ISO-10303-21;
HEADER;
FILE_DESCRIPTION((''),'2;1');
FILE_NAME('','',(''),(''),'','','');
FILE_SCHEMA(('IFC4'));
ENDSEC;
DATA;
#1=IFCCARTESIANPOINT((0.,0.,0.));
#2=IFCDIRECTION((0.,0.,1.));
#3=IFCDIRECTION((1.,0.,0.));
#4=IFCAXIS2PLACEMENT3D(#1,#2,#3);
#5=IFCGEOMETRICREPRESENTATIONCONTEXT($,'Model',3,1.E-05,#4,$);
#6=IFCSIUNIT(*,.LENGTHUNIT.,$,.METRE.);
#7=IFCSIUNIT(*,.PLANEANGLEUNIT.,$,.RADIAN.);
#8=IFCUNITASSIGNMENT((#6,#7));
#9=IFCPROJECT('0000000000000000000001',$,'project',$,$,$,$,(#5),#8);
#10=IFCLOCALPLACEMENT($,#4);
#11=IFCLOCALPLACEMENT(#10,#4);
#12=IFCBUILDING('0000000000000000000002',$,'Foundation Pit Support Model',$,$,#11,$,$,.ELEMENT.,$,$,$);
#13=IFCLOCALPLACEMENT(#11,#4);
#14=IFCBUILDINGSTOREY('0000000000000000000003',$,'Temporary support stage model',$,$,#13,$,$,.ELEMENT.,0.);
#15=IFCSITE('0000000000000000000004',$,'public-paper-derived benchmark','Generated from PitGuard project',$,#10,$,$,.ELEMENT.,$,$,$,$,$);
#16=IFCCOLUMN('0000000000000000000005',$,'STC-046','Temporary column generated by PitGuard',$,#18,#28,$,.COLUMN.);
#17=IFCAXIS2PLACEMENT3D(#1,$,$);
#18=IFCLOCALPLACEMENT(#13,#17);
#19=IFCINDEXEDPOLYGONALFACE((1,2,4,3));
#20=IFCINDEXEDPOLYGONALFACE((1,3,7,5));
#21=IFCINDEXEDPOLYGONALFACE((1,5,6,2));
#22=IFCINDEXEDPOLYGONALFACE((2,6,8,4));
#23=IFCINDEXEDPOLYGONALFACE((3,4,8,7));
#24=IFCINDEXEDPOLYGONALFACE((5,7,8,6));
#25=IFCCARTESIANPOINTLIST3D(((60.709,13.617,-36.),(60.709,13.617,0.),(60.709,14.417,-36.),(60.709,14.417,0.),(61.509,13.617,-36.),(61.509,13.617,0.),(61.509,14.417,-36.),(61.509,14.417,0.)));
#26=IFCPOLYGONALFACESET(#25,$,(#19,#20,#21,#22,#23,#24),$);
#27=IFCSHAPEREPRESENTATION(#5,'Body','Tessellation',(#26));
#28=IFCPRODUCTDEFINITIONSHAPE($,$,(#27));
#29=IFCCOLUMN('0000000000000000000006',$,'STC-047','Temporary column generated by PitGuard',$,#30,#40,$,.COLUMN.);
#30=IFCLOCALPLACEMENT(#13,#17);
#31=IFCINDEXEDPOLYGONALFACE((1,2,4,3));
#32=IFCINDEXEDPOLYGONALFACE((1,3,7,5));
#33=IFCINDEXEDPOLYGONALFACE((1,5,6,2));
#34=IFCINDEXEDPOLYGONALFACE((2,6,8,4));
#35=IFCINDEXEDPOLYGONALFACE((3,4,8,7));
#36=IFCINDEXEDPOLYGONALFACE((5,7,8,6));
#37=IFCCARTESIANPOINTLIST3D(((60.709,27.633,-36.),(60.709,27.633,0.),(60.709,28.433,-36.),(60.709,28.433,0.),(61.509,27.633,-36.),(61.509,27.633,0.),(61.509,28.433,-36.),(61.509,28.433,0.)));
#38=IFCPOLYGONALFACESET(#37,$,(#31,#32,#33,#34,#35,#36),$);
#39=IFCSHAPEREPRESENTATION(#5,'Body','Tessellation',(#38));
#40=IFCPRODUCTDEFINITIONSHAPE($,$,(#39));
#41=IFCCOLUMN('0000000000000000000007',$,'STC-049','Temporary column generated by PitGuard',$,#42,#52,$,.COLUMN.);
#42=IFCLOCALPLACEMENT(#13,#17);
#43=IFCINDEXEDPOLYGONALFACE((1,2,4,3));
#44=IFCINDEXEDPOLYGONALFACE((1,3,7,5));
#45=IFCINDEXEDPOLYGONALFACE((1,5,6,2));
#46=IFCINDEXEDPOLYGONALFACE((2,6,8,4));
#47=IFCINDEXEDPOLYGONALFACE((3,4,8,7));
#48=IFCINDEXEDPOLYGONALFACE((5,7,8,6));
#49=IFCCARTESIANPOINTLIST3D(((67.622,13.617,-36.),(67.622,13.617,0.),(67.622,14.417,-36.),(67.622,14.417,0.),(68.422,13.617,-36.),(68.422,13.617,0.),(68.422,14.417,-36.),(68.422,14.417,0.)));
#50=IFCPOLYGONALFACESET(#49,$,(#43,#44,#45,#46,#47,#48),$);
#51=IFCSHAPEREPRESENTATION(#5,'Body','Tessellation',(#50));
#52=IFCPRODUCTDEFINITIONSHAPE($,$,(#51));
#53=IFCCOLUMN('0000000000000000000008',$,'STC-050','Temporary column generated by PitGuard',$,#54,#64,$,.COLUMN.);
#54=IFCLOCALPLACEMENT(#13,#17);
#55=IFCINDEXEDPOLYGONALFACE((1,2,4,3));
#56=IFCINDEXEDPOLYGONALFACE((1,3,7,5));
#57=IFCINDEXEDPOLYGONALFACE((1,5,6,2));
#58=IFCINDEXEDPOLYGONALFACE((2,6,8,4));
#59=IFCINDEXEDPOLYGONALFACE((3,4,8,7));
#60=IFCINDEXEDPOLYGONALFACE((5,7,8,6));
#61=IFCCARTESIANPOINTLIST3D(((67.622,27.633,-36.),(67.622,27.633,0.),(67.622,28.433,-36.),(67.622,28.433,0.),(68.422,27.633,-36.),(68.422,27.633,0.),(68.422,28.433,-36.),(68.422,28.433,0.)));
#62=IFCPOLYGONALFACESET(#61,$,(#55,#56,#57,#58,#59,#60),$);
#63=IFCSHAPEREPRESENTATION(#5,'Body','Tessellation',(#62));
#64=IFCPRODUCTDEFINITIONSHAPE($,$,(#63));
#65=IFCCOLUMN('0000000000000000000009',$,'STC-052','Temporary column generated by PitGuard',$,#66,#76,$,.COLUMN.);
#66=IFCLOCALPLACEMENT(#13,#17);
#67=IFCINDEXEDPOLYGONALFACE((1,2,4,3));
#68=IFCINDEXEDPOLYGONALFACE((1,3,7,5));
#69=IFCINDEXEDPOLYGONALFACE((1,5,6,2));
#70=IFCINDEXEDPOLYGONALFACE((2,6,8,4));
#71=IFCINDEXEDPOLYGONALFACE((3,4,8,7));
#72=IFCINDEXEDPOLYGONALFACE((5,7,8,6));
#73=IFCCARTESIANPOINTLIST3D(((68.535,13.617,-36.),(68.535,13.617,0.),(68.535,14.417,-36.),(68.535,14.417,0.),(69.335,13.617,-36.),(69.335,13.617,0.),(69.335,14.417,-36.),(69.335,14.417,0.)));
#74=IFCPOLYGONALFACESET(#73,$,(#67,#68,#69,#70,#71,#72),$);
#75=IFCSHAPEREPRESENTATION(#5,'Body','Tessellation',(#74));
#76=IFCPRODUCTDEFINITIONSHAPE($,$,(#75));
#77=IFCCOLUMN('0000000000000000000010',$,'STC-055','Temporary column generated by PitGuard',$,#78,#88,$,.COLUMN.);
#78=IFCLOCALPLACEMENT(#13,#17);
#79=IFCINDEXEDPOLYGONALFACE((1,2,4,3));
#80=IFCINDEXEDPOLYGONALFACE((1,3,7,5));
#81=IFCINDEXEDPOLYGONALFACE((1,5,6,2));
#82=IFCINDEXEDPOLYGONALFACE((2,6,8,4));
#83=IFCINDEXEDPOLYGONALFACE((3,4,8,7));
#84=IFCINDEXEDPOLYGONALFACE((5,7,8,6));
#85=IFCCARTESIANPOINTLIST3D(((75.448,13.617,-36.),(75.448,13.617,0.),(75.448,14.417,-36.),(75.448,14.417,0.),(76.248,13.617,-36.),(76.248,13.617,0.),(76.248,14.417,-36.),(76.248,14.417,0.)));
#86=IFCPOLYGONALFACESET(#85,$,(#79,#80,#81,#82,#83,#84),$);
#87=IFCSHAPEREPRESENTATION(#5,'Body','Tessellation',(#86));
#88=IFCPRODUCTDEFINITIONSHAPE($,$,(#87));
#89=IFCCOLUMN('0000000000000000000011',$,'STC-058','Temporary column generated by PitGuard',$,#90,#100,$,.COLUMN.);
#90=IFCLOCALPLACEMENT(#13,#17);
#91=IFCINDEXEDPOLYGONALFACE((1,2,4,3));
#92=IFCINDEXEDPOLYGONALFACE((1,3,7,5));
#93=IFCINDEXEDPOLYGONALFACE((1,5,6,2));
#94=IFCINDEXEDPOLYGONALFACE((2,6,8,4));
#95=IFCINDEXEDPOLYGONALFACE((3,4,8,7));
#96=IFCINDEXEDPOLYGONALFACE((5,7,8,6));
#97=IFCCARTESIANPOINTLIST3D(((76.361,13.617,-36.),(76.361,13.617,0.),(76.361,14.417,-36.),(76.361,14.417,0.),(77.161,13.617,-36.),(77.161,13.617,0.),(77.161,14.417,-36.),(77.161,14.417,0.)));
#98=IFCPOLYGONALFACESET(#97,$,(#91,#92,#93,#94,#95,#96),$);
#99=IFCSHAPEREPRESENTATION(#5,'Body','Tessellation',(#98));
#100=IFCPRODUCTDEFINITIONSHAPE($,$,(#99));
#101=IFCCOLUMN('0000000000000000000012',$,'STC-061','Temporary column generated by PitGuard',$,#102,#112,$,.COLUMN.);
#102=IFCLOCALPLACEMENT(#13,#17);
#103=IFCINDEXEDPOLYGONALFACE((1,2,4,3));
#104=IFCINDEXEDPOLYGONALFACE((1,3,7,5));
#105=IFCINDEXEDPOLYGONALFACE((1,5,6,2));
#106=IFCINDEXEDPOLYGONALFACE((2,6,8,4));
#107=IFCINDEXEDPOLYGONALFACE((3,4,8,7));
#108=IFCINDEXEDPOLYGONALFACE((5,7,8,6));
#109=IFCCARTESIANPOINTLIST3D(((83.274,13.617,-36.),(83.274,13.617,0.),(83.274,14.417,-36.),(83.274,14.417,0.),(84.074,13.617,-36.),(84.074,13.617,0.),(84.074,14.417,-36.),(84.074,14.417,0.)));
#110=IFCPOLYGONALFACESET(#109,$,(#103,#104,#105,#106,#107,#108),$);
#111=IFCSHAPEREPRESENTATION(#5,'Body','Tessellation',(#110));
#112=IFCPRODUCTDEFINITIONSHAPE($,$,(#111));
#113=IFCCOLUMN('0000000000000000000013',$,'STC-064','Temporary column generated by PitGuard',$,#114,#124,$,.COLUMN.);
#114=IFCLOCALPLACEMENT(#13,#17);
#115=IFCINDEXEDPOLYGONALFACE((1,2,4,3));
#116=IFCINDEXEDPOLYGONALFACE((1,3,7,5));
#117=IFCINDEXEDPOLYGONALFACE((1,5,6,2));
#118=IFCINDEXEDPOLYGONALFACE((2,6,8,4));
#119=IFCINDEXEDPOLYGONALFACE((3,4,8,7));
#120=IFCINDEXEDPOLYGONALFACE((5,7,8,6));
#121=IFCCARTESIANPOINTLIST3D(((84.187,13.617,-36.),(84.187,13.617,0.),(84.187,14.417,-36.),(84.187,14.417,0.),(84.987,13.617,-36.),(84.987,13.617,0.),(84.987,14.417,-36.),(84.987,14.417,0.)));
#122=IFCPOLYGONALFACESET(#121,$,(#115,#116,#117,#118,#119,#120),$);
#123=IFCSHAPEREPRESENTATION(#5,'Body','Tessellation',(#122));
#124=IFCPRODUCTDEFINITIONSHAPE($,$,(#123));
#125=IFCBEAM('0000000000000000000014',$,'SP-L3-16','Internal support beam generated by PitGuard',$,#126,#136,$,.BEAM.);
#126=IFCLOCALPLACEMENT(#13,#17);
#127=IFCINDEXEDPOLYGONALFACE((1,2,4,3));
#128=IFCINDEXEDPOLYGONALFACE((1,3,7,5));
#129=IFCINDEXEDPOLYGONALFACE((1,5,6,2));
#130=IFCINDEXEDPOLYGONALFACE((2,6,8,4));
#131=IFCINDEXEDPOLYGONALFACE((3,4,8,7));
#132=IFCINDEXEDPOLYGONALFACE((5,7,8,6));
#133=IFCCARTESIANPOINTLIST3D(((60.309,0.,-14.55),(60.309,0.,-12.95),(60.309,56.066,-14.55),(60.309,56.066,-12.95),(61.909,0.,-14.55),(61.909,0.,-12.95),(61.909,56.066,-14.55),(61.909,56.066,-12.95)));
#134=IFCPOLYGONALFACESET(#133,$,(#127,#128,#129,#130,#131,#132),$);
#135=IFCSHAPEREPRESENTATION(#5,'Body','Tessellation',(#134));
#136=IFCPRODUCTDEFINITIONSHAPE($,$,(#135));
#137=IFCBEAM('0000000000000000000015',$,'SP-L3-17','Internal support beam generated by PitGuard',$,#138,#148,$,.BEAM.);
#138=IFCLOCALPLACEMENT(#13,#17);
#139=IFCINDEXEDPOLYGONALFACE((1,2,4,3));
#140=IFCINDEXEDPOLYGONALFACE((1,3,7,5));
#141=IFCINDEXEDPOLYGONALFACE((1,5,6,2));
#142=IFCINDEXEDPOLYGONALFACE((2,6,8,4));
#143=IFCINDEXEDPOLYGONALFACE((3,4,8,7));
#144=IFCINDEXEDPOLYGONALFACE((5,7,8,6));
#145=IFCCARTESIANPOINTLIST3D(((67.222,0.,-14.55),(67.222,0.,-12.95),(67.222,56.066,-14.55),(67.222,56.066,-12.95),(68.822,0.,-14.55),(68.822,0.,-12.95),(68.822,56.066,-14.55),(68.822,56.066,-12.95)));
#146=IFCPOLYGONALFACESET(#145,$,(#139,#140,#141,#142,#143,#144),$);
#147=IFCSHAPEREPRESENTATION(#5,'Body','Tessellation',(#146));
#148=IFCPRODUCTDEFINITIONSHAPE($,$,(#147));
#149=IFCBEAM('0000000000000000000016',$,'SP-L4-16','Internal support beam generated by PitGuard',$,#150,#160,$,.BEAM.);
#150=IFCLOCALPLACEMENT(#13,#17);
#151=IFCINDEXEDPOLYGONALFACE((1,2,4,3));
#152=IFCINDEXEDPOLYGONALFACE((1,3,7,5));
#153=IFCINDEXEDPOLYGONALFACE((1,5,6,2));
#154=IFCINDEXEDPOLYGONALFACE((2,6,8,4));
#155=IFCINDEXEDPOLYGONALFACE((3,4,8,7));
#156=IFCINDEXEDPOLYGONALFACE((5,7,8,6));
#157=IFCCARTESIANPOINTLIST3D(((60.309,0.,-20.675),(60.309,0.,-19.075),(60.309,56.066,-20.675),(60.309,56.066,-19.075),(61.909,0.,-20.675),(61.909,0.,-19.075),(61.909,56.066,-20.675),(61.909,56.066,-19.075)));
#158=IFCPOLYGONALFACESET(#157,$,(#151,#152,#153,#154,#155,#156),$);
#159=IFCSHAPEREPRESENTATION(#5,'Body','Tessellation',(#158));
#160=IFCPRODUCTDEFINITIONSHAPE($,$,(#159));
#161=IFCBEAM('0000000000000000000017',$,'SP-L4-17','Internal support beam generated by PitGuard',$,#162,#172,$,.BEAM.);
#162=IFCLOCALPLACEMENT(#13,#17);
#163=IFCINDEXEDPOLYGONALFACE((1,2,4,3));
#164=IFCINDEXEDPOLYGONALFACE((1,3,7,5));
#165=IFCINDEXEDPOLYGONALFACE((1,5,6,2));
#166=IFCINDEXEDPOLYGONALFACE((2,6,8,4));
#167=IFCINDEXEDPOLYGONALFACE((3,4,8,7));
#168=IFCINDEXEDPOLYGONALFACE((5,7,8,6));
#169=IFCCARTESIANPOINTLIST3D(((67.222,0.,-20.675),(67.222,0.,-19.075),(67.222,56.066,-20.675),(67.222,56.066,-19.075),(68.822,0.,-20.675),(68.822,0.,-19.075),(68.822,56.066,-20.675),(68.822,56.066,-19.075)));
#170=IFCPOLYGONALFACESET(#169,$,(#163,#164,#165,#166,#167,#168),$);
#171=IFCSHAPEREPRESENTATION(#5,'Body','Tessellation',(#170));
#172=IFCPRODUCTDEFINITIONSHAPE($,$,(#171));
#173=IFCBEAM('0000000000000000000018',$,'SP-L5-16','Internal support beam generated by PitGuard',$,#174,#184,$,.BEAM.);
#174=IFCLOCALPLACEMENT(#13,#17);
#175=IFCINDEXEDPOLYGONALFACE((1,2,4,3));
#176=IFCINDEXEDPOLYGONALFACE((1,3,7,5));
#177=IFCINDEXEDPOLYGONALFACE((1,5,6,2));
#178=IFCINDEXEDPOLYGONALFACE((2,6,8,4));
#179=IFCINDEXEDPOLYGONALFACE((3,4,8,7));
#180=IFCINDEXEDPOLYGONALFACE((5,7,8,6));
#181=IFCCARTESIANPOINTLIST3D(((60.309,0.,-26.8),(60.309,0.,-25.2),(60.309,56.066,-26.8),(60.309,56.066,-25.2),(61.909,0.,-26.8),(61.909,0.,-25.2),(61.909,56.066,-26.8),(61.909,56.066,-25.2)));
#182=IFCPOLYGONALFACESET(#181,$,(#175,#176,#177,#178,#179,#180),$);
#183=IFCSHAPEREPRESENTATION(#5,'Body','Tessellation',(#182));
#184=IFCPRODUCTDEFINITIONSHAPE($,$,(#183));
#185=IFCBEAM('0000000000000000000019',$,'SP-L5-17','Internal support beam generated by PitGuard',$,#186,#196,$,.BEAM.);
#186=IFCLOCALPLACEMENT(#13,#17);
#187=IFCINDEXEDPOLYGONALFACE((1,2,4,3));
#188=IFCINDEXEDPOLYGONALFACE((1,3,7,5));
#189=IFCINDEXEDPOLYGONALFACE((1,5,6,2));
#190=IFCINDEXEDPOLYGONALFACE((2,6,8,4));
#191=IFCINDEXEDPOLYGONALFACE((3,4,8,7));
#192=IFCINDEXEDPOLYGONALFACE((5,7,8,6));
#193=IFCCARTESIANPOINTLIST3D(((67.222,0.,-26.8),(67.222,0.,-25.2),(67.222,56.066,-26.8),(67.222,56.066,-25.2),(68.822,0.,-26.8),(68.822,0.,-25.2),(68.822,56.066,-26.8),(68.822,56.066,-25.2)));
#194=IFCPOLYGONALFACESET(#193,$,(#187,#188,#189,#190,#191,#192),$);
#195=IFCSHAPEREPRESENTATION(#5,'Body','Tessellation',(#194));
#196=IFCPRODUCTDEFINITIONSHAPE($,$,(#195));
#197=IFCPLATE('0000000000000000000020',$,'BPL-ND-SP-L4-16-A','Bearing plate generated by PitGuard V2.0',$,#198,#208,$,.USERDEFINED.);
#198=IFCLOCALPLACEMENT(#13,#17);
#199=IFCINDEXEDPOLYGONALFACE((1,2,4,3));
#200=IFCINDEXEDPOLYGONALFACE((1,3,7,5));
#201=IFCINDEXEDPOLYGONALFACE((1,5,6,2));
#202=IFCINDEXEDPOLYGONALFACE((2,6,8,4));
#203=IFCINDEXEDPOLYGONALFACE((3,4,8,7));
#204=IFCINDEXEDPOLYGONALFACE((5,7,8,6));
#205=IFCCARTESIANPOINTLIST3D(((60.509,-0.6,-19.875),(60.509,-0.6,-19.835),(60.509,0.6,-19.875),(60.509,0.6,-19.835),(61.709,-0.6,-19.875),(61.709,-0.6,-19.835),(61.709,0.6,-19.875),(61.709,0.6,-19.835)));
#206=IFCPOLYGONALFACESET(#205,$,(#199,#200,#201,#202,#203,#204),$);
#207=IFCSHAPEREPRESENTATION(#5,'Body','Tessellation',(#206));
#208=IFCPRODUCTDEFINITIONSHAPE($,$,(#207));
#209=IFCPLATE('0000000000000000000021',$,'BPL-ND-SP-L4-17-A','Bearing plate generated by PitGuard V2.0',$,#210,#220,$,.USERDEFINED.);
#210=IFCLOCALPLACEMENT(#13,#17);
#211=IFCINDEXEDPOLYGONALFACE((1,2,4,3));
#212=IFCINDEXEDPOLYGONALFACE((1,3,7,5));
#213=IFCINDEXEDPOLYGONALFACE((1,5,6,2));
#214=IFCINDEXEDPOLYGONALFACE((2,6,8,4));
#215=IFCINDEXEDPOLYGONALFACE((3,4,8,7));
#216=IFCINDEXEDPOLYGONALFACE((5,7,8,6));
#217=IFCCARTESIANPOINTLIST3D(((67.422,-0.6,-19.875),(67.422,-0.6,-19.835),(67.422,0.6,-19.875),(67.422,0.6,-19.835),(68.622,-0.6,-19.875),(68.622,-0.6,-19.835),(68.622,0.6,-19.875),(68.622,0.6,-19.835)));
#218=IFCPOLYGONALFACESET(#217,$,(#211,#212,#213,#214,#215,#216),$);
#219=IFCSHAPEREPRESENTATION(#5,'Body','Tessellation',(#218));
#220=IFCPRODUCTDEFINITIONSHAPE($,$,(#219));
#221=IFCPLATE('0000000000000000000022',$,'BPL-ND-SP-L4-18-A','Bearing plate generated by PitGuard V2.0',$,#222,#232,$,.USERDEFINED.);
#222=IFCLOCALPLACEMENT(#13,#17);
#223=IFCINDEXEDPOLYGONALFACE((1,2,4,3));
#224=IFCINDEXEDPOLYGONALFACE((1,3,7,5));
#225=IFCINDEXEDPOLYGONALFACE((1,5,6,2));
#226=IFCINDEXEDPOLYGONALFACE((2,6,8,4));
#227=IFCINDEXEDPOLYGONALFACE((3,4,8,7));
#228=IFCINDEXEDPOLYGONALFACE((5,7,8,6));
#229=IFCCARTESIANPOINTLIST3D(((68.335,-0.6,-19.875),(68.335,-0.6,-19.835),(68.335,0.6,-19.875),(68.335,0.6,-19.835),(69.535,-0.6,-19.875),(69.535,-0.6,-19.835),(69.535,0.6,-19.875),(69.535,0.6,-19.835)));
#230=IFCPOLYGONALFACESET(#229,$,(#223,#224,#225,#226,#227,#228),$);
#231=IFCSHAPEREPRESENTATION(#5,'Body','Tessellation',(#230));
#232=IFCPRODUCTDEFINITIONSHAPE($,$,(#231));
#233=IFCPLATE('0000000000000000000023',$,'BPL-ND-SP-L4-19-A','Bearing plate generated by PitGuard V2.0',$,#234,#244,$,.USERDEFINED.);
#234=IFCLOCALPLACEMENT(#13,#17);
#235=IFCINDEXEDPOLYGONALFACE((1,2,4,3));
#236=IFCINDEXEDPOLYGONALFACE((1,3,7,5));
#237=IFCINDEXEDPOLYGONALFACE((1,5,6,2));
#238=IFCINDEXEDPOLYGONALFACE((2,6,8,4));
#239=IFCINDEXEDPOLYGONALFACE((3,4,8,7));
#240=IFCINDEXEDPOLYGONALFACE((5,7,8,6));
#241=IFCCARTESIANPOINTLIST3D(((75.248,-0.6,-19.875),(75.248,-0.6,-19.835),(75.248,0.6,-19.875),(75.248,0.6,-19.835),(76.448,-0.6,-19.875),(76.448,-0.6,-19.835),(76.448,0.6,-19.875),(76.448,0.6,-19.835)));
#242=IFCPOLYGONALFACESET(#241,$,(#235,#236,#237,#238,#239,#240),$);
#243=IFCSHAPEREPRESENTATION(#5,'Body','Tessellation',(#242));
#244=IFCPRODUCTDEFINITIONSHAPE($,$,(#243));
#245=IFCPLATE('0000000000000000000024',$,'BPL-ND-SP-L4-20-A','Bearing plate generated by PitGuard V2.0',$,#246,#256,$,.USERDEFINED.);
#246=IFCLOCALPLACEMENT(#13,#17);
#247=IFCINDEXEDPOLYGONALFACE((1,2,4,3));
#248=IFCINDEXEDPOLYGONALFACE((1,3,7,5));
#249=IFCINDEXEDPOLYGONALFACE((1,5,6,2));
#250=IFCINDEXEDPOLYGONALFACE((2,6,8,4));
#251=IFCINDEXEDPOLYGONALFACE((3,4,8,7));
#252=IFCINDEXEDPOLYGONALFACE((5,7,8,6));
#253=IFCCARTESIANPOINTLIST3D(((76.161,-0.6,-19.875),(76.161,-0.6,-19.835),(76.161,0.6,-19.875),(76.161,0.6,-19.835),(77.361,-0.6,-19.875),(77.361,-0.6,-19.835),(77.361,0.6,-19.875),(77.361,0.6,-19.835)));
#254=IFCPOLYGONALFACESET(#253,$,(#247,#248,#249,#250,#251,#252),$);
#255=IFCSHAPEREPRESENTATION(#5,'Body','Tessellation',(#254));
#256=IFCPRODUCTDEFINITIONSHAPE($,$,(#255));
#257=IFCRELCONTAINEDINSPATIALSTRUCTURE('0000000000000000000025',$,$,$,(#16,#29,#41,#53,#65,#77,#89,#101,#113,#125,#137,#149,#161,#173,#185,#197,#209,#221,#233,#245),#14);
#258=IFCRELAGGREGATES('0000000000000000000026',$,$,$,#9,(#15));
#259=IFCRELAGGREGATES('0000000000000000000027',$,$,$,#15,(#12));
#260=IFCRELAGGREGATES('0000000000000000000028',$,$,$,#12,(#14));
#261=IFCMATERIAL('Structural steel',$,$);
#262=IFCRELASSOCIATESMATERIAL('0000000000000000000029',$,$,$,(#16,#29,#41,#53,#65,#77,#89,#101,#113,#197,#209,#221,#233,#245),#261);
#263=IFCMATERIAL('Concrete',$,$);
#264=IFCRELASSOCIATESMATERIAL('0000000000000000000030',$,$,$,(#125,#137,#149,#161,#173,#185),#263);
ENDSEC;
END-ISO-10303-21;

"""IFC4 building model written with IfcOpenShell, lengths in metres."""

from ifc_helpers import new_model, si_unit, frame, origin_with_axes, origin_2d, place, context, project, spatial, rectangle, extrude, material, element, save


model = new_model("IFC4")

# Units and contexts
model_context = context("Model", 3, precision=1e-05, world=origin_with_axes())
ifc_project = project(units=[si_unit("LENGTHUNIT", "METRE"), si_unit("PLANEANGLEUNIT", "RADIAN")], contexts=[model_context])

# Site, building, storey
site_placement = place(None, origin_with_axes())
site = spatial("IfcSite", under=ifc_project, at=site_placement, Name="public-paper-derived benchmark", Description="Generated from PitGuard project", CompositionType="ELEMENT")
building_placement = place(site_placement, origin_with_axes())
building = spatial("IfcBuilding", under=site, at=building_placement, Name="Foundation Pit Support Model", CompositionType="ELEMENT")
storey_placement = place(building_placement, origin_with_axes())
storey = spatial("IfcBuildingStorey", under=building, at=storey_placement, Name="Temporary support stage model", CompositionType="ELEMENT", Elevation=0.0)

# Columns
ifc_material_1 = material(Name="Structural steel")
for number, where, z_axis, x_axis, name in (
    (1, (61.109, 14.017, -36.0), (0.0, 0.0, 1.0), (1.0, 0.0, 0.0), "STC-046"),
    (2, (61.109, 28.033, -36.0), (0.0, 0.0, 1.0), (1.0, 0.0, 0.0), "STC-047"),
    (3, (68.022, 14.017, -36.0), (0.0, 0.0, 1.0), (1.0, 0.0, 0.0), "STC-049"),
    (4, (68.022, 28.033, -36.0), (0.0, 0.0, 1.0), (1.0, 0.0, 0.0), "STC-050"),
    (5, (68.935, 14.017, -36.0), (0.0, 0.0, 1.0), (1.0, 0.0, 0.0), "STC-052"),
    (6, (75.848, 14.017, -36.0), (0.0, 0.0, 1.0), (1.0, 0.0, 0.0), "STC-055"),
    (7, (76.761, 14.017, -36.0), (0.0, 0.0, 1.0), (1.0, 0.0, 0.0), "STC-058"),
    (8, (83.674, 14.017, -36.0), (0.0, 0.0, 1.0), (1.0, 0.0, 0.0), "STC-061"),
    (9, (84.587, 14.017, -36.0), (0.0, 0.0, 1.0), (1.0, 0.0, 0.0), "STC-064"),
):
    element("IfcColumn", number, at=place(storey_placement, frame(where, z_axis=z_axis, x_axis=x_axis)), inside=storey, material=ifc_material_1, Name=name, Description="Temporary column generated by PitGuard", PredefinedType="COLUMN", context=model_context, shape_type="SweptSolid", body=[
        extrude(rectangle(XDim=0.8, YDim=0.8, at=origin_2d()), origin_with_axes(), (0.0, 0.0, 1.0), 36.0),
    ])

# Beams
ifc_material_2 = material(Name="Concrete")
for number, where, z_axis, x_axis, name in (
    (10, (61.109, 28.033, -14.55), (0.0, 0.0, 1.0), (0.0, 1.0, 0.0), "SP-L3-16"),
    (11, (68.022, 28.033, -14.55), (0.0, 0.0, 1.0), (0.0, 1.0, 0.0), "SP-L3-17"),
    (12, (61.109, 28.033, -20.675), (0.0, 0.0, 1.0), (0.0, 1.0, 0.0), "SP-L4-16"),
    (13, (68.022, 28.033, -20.675), (0.0, 0.0, 1.0), (0.0, 1.0, 0.0), "SP-L4-17"),
    (14, (61.109, 28.033, -26.8), (0.0, 0.0, 1.0), (0.0, 1.0, 0.0), "SP-L5-16"),
    (15, (68.022, 28.033, -26.8), (0.0, 0.0, 1.0), (0.0, 1.0, 0.0), "SP-L5-17"),
):
    element("IfcBeam", number, at=place(storey_placement, frame(where, z_axis=z_axis, x_axis=x_axis)), inside=storey, material=ifc_material_2, Name=name, Description="Internal support beam generated by PitGuard", PredefinedType="BEAM", context=model_context, shape_type="SweptSolid", body=[
        extrude(rectangle(XDim=56.066, YDim=1.6, at=origin_2d()), origin_with_axes(), (0.0, 0.0, 1.0), 1.6),
    ])

# Plates
for number, where, z_axis, x_axis, name in (
    (16, (61.109, 0.0, -19.875), (0.0, 0.0, 1.0), (1.0, 0.0, 0.0), "BPL-ND-SP-L4-16-A"),
    (17, (68.022, 0.0, -19.875), (0.0, 0.0, 1.0), (1.0, 0.0, 0.0), "BPL-ND-SP-L4-17-A"),
    (18, (68.935, 0.0, -19.875), (0.0, 0.0, 1.0), (1.0, 0.0, 0.0), "BPL-ND-SP-L4-18-A"),
    (19, (75.848, 0.0, -19.875), (0.0, 0.0, 1.0), (1.0, 0.0, 0.0), "BPL-ND-SP-L4-19-A"),
    (20, (76.761, 0.0, -19.875), (0.0, 0.0, 1.0), (1.0, 0.0, 0.0), "BPL-ND-SP-L4-20-A"),
):
    element("IfcPlate", number, at=place(storey_placement, frame(where, z_axis=z_axis, x_axis=x_axis)), inside=storey, material=ifc_material_1, Name=name, Description="Bearing plate generated by PitGuard V2.0", PredefinedType="USERDEFINED", context=model_context, shape_type="SweptSolid", body=[
        extrude(rectangle(XDim=1.2, YDim=1.2, at=origin_2d()), origin_with_axes(), (0.0, 0.0, 1.0), 0.04),
    ])

save(model, "model.ifc")
